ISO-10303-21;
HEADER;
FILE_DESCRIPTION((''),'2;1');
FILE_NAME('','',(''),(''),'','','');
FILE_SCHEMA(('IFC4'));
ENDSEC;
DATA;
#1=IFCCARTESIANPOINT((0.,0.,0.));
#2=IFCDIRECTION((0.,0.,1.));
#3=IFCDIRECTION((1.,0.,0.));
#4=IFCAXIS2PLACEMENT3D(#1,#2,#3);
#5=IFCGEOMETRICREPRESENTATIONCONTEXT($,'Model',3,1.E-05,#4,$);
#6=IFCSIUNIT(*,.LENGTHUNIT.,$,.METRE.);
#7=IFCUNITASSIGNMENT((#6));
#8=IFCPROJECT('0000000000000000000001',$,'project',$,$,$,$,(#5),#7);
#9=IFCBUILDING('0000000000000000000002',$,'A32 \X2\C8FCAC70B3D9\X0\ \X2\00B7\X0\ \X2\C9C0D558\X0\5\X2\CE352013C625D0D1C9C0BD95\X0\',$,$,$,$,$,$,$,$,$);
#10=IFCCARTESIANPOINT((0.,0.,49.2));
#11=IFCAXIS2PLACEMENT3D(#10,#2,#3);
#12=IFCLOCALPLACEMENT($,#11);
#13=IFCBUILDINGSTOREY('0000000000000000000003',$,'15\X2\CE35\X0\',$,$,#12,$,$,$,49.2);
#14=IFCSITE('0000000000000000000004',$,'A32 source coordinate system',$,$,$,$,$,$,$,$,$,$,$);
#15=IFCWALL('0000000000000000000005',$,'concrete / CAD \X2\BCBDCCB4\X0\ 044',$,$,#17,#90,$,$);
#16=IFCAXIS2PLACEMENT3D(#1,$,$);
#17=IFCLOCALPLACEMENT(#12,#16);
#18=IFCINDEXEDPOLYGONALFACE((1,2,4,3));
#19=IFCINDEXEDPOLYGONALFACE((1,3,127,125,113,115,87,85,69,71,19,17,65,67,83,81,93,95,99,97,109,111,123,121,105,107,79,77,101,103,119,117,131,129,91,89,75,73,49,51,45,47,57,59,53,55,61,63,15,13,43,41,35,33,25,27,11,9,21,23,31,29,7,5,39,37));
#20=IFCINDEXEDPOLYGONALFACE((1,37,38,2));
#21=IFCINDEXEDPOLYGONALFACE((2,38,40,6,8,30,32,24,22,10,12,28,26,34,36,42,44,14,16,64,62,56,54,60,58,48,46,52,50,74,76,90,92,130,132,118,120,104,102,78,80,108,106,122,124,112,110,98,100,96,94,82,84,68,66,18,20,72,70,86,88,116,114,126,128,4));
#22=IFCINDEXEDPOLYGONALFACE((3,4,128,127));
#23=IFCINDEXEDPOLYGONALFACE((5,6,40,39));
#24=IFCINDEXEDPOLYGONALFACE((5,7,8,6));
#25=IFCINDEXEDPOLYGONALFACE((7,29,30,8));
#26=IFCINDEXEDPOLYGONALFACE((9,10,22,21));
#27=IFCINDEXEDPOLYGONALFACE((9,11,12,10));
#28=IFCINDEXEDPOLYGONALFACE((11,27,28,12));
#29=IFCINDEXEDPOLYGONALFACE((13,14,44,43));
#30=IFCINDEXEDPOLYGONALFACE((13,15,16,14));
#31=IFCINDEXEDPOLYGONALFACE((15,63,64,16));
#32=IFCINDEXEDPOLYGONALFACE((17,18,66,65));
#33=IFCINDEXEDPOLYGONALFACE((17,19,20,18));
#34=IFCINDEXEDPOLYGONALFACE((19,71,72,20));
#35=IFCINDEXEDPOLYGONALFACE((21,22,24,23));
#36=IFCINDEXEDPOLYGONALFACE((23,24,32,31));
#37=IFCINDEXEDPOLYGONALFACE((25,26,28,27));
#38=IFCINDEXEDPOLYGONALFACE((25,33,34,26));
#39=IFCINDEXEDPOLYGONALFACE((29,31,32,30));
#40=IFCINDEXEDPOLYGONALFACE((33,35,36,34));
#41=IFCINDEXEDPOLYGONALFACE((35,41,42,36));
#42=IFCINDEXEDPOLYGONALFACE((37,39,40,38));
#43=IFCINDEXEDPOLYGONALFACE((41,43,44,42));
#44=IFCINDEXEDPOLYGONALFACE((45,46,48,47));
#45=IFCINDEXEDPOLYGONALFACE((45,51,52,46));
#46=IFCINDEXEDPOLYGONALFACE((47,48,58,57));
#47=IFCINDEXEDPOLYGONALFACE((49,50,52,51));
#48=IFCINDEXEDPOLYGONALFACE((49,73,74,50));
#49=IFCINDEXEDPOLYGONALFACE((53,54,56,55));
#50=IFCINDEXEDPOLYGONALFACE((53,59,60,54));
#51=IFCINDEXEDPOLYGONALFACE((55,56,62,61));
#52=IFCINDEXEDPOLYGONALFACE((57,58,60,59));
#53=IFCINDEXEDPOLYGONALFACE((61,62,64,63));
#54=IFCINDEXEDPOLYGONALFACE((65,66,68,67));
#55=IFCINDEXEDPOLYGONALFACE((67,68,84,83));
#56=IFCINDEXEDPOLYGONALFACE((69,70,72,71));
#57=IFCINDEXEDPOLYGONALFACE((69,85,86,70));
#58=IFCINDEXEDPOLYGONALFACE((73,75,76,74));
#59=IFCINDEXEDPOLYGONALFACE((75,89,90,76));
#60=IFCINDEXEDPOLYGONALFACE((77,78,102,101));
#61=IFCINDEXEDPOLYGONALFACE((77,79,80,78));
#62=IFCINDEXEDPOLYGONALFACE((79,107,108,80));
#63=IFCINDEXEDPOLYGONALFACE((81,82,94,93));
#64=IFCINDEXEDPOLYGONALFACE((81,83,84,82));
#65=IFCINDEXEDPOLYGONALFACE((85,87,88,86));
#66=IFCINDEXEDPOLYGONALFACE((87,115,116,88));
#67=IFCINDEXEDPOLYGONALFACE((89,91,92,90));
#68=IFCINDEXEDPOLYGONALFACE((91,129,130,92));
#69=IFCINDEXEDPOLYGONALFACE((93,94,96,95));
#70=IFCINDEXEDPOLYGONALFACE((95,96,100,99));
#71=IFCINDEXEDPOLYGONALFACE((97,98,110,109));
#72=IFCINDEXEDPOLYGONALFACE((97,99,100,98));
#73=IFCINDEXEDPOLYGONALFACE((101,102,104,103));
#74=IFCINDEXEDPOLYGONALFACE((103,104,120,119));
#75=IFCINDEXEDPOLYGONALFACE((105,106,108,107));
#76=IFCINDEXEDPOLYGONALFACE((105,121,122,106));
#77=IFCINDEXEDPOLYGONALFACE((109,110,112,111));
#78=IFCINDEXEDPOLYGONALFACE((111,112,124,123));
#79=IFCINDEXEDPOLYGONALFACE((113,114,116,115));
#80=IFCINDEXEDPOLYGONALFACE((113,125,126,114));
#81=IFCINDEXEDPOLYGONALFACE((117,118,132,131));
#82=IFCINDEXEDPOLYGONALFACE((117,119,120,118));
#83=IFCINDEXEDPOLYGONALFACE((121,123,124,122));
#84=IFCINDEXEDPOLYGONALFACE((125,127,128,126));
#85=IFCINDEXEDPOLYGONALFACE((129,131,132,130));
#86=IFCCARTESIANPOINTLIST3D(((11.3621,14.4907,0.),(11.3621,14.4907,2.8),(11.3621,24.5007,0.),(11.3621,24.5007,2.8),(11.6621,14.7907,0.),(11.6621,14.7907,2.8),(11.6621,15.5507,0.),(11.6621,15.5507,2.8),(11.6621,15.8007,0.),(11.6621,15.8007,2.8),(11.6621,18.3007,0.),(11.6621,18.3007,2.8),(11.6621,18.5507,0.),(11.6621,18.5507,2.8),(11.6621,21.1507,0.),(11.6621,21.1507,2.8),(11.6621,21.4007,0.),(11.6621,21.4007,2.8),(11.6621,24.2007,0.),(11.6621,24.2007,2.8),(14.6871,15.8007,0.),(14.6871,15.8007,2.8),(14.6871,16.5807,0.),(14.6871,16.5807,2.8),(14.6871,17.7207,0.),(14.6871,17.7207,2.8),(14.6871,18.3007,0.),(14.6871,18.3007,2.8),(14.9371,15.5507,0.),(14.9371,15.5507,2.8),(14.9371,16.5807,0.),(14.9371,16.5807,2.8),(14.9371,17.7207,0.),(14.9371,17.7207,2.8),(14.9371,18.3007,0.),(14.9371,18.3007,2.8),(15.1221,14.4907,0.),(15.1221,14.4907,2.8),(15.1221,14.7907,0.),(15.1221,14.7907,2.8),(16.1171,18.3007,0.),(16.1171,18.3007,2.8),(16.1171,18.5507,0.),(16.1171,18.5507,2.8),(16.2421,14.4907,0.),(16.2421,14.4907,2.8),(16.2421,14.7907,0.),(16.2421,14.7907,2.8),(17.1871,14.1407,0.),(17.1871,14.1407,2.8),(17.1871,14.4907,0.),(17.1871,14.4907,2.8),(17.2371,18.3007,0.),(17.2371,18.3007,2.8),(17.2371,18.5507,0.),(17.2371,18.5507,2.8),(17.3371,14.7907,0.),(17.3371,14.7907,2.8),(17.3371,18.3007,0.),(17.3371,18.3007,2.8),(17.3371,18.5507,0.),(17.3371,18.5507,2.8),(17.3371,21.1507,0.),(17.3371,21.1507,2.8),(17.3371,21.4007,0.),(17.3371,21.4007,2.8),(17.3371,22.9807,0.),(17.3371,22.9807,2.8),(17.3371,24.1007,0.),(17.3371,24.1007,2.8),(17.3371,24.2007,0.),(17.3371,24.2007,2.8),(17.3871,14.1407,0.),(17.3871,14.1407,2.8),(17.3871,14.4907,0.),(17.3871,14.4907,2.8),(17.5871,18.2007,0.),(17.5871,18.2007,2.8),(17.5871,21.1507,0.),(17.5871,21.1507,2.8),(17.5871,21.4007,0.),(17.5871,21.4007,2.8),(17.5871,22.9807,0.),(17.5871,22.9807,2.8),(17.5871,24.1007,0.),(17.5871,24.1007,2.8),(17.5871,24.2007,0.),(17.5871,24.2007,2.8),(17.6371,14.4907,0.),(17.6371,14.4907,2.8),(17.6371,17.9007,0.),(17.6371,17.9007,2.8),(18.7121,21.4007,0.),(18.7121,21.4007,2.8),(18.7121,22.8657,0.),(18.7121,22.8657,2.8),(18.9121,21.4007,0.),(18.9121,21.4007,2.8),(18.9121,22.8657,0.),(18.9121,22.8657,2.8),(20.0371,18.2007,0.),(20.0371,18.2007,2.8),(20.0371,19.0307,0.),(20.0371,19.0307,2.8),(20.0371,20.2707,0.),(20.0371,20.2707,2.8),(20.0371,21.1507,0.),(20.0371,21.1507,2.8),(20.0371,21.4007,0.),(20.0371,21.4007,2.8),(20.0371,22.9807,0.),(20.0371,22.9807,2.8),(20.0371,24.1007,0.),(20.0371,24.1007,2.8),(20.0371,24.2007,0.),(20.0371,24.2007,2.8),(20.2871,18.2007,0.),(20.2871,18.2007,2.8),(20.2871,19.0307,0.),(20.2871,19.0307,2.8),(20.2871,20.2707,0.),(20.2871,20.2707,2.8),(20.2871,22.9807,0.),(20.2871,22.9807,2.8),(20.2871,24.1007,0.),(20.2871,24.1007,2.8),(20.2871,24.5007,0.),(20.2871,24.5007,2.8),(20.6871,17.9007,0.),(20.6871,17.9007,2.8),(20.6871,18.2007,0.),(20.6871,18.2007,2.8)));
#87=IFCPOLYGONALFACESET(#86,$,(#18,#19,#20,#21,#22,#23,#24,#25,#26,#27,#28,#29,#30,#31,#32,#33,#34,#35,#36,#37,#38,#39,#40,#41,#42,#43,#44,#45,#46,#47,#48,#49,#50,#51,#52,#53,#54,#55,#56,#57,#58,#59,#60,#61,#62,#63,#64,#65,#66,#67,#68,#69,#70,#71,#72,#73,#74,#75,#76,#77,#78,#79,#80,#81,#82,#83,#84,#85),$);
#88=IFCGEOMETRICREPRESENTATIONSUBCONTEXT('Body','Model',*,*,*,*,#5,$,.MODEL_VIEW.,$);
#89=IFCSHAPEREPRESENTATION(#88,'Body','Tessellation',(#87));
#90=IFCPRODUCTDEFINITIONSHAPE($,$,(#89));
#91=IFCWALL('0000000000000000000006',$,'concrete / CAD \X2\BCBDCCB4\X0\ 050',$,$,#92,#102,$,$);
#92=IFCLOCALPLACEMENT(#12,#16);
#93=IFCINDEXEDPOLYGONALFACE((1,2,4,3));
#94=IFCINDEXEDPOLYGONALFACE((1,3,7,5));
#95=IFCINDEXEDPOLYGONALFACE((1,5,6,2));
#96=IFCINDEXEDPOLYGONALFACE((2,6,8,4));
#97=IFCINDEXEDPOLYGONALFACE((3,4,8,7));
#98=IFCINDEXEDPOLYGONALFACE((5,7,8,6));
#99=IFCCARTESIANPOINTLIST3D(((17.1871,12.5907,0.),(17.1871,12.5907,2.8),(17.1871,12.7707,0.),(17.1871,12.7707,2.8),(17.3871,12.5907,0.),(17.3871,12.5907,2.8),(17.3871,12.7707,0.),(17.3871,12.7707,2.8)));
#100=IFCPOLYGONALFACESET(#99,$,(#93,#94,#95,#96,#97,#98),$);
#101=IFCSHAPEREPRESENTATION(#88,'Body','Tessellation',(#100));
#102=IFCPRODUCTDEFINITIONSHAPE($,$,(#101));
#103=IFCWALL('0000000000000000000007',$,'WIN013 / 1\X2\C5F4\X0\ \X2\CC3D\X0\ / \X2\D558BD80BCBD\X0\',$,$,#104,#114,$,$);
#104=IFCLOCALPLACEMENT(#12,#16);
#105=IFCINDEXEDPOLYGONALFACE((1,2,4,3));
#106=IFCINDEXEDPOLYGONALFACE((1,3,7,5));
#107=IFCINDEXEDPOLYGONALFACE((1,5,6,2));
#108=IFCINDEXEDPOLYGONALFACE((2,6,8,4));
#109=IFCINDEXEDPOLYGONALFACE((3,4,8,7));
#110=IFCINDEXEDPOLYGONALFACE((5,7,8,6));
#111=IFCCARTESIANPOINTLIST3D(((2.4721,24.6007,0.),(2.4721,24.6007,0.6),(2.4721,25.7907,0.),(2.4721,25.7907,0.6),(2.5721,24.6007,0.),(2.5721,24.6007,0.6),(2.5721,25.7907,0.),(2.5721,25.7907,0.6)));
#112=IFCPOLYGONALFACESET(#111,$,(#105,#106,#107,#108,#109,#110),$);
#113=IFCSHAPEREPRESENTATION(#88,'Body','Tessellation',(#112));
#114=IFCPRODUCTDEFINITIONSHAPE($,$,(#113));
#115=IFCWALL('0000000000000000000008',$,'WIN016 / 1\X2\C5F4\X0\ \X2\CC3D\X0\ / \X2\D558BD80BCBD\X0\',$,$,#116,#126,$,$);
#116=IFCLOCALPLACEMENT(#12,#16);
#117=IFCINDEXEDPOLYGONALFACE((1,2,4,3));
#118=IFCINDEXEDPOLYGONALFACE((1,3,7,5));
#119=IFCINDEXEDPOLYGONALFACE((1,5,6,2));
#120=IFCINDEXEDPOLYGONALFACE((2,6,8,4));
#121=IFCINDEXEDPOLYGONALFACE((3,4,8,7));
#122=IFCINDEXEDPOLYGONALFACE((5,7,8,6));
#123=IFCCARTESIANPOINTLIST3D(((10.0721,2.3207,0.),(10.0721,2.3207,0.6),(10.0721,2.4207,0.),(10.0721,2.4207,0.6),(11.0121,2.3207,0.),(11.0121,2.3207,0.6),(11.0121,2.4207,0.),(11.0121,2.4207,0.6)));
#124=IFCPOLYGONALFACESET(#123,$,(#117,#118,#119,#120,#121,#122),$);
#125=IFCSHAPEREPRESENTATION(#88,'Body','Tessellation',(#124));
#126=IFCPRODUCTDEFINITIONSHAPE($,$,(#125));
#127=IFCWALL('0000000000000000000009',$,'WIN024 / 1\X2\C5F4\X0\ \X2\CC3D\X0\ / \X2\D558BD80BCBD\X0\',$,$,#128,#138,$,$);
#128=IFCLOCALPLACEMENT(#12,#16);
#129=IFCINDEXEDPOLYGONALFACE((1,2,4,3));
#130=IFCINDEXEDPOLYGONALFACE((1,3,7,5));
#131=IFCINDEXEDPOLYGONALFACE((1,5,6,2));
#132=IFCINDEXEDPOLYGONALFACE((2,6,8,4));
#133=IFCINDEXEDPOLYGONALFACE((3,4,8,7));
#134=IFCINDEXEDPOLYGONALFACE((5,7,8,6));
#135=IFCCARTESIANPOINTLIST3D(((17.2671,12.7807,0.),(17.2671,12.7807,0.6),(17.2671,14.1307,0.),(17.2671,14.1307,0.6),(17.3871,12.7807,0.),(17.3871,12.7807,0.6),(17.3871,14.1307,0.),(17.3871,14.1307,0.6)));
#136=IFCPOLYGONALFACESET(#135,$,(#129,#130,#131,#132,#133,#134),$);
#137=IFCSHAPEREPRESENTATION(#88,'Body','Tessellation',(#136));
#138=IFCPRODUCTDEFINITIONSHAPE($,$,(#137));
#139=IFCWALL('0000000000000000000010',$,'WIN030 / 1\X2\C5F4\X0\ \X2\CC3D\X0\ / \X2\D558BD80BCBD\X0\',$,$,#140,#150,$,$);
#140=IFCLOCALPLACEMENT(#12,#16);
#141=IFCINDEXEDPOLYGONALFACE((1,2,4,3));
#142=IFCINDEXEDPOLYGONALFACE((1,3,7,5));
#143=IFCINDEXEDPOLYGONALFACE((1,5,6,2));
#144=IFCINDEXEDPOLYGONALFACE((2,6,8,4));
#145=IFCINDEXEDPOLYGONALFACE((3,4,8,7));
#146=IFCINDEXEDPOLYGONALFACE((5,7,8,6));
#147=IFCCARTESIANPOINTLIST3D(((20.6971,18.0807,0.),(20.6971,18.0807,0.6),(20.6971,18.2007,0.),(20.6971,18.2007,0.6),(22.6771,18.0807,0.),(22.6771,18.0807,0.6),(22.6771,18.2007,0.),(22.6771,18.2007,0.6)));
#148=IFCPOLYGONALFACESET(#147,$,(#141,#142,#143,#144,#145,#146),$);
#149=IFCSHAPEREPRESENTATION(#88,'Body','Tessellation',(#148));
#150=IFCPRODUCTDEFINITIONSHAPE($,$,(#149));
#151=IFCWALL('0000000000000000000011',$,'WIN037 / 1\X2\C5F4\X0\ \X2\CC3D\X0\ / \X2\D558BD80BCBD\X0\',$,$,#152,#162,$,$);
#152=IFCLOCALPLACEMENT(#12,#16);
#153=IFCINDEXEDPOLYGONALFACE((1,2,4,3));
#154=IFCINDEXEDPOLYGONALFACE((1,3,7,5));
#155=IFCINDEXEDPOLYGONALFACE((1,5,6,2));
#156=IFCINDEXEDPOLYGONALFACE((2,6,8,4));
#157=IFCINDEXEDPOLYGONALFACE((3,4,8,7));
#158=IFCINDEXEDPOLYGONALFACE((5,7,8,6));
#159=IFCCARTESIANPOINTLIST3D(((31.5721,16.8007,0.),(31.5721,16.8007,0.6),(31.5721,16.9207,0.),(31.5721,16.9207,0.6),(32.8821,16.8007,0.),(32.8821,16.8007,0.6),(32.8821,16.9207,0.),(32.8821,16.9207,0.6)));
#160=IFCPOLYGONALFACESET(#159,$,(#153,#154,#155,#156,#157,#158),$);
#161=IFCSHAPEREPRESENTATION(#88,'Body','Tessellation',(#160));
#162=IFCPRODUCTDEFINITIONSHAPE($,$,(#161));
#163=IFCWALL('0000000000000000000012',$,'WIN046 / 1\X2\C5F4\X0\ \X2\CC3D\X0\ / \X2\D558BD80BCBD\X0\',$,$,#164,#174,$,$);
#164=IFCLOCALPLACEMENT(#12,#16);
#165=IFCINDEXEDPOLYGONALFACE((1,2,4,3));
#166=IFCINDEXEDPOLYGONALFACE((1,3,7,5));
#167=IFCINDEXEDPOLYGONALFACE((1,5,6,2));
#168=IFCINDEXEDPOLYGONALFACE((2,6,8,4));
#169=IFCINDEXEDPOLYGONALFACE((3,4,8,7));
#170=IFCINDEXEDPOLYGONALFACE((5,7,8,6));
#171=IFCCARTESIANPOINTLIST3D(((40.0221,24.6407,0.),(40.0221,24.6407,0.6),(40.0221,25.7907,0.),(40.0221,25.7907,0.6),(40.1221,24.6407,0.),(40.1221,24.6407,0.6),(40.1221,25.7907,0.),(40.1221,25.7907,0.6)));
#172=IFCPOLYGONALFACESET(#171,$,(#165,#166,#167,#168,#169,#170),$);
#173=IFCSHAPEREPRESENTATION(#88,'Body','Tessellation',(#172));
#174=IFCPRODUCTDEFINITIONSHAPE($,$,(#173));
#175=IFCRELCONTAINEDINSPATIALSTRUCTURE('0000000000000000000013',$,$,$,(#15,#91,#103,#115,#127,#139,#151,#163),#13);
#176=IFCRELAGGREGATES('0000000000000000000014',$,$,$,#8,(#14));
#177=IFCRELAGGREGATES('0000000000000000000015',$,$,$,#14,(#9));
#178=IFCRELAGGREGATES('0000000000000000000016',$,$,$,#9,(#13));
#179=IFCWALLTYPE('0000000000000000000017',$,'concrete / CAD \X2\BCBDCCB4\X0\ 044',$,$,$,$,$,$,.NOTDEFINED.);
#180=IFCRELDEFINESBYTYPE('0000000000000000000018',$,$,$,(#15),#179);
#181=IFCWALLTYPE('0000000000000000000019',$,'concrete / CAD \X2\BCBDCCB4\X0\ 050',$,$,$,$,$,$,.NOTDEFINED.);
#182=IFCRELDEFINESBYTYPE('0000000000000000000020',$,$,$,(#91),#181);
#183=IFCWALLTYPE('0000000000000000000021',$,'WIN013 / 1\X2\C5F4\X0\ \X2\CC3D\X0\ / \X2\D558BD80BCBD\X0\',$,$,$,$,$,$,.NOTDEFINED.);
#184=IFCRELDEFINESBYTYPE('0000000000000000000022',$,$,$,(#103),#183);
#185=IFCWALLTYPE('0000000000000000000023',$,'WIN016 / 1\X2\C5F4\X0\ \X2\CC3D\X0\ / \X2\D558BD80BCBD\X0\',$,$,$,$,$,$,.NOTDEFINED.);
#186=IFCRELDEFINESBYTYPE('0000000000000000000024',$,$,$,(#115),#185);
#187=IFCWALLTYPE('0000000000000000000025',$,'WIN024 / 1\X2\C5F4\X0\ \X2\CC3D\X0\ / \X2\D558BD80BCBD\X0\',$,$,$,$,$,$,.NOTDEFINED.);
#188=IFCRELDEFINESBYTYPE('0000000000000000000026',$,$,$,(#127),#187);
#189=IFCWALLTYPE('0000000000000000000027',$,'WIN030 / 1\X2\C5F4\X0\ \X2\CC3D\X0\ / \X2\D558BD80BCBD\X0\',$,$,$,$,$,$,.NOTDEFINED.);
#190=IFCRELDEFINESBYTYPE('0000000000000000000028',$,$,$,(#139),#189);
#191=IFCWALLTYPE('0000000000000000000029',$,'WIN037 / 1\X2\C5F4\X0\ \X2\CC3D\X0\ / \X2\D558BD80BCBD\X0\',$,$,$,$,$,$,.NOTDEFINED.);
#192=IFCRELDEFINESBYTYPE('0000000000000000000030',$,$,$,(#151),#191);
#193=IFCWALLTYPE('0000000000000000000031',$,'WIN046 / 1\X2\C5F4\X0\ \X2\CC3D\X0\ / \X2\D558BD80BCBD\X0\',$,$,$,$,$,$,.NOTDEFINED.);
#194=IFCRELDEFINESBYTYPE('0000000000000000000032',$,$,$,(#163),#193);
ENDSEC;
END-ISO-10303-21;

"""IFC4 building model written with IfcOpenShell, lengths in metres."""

from ifc_helpers import new_model, si_unit, frame, origin, origin_with_axes, place, context, subcontext, project, spatial, polyline, outline, extrude, source, transform, mapped, type_object, type_shapes, element, save


model = new_model("IFC4")

# Units and contexts
model_context = context("Model", 3, precision=1e-05, world=origin_with_axes())
body_context = subcontext(model_context, "Body", "Model", "MODEL_VIEW")
ifc_project = project(units=[si_unit("LENGTHUNIT", "METRE")], contexts=[model_context])

# Site, building, storey
site = spatial("IfcSite", under=ifc_project, Name="A32 source coordinate system")
building = spatial("IfcBuilding", under=site, Name="A32 주거동 · 지하5층–옥탑지붕")
storey_placement = place(None, frame((0.0, 0.0, 49.2), z_axis=(0.0, 0.0, 1.0), x_axis=(1.0, 0.0, 0.0)))
storey = spatial("IfcBuildingStorey", under=building, at=storey_placement, Name="15층", Elevation=49.2)

# Walls
wall_type_1 = type_object("IfcWallType", Name="concrete / CAD 벽체 044", PredefinedType="NOTDEFINED")
shared_shape_1 = source(origin(), body_context, "Body", "SweptSolid", [
    extrude(outline(polyline([(17.3371, 21.4007), (17.3371, 22.9807), (17.5871, 22.9807), (17.5871, 21.4007), (18.7121, 21.4007), (18.7121, 22.8657), (18.9121, 22.8657), (18.9121, 21.4007), (20.0371, 21.4007), (20.0371, 22.9807), (20.2871, 22.9807), (20.2871, 20.2707), (20.0371, 20.2707), (20.0371, 21.1507), (17.5871, 21.1507), (17.5871, 18.2007), (20.0371, 18.2007), (20.0371, 19.0307), (20.2871, 19.0307), (20.2871, 18.2007), (20.6871, 18.2007), (20.6871, 17.9007), (17.6371, 17.9007), (17.6371, 14.4907), (17.3871, 14.4907), (17.3871, 14.1407), (17.1871, 14.1407), (17.1871, 14.4907), (16.2421, 14.4907), (16.2421, 14.7907), (17.3371, 14.7907), (17.3371, 18.3007), (17.2371, 18.3007), (17.2371, 18.5507), (17.3371, 18.5507), (17.3371, 21.1507), (11.6621, 21.1507), (11.6621, 18.5507), (16.1171, 18.5507), (16.1171, 18.3007), (14.9371, 18.3007), (14.9371, 17.7207), (14.6871, 17.7207), (14.6871, 18.3007), (11.6621, 18.3007), (11.6621, 15.8007), (14.6871, 15.8007), (14.6871, 16.5807), (14.9371, 16.5807), (14.9371, 15.5507), (11.6621, 15.5507), (11.6621, 14.7907), (15.1221, 14.7907), (15.1221, 14.4907), (11.3621, 14.4907), (11.3621, 24.5007), (20.2871, 24.5007), (20.2871, 24.1007), (20.0371, 24.1007), (20.0371, 24.2007), (17.5871, 24.2007), (17.5871, 24.1007), (17.3371, 24.1007), (17.3371, 24.2007), (11.6621, 24.2007), (11.6621, 21.4007), (17.3371, 21.4007)])), origin(), (0.0, 0.0, 1.0), 2.8),
])
type_shapes(wall_type_1, [shared_shape_1])
wall_1_placement = place(storey_placement, origin_with_axes())
element("IfcWall", 1, at=wall_1_placement, inside=storey, type_object=wall_type_1, Name="concrete / CAD 벽체 044", context=body_context, shape_type="MappedRepresentation", body=[
    mapped(shared_shape_1, transform((0.0, 0.0, 0.0), scale=1.0)),
])
wall_type_2 = type_object("IfcWallType", Name="concrete / CAD 벽체 050", PredefinedType="NOTDEFINED")
shared_shape_2 = source(origin(), body_context, "Body", "SweptSolid", [
    extrude(outline(polyline([(17.3871, 12.5907), (17.1871, 12.5907), (17.1871, 12.7707), (17.3871, 12.7707), (17.3871, 12.5907)])), origin(), (0.0, 0.0, 1.0), 2.8),
])
type_shapes(wall_type_2, [shared_shape_2])
wall_2_placement = place(storey_placement, origin_with_axes())
element("IfcWall", 2, at=wall_2_placement, inside=storey, type_object=wall_type_2, Name="concrete / CAD 벽체 050", context=body_context, shape_type="MappedRepresentation", body=[
    mapped(shared_shape_2, transform((0.0, 0.0, 0.0), scale=1.0)),
])
wall_type_3 = type_object("IfcWallType", Name="WIN013 / 1열 창 / 하부벽", PredefinedType="NOTDEFINED")
shared_shape_3 = source(origin(), body_context, "Body", "SweptSolid", [
    extrude(outline(polyline([(2.5721, 25.7907), (2.5721, 24.6007), (2.4721, 24.6007), (2.4721, 25.7907), (2.5721, 25.7907)])), origin(), (0.0, 0.0, 1.0), 0.6),
])
type_shapes(wall_type_3, [shared_shape_3])
wall_3_placement = place(storey_placement, origin_with_axes())
element("IfcWall", 3, at=wall_3_placement, inside=storey, type_object=wall_type_3, Name="WIN013 / 1열 창 / 하부벽", context=body_context, shape_type="MappedRepresentation", body=[
    mapped(shared_shape_3, transform((0.0, 0.0, 0.0), scale=1.0)),
])
wall_type_4 = type_object("IfcWallType", Name="WIN016 / 1열 창 / 하부벽", PredefinedType="NOTDEFINED")
shared_shape_4 = source(origin(), body_context, "Body", "SweptSolid", [
    extrude(outline(polyline([(11.0121, 2.4207), (11.0121, 2.3207), (10.0721, 2.3207), (10.0721, 2.4207), (11.0121, 2.4207)])), origin(), (0.0, 0.0, 1.0), 0.6),
])
type_shapes(wall_type_4, [shared_shape_4])
wall_4_placement = place(storey_placement, origin_with_axes())
element("IfcWall", 4, at=wall_4_placement, inside=storey, type_object=wall_type_4, Name="WIN016 / 1열 창 / 하부벽", context=body_context, shape_type="MappedRepresentation", body=[
    mapped(shared_shape_4, transform((0.0, 0.0, 0.0), scale=1.0)),
])
wall_type_5 = type_object("IfcWallType", Name="WIN024 / 1열 창 / 하부벽", PredefinedType="NOTDEFINED")
shared_shape_5 = source(origin(), body_context, "Body", "SweptSolid", [
    extrude(outline(polyline([(17.3871, 14.1307), (17.3871, 12.7807), (17.2671, 12.7807), (17.2671, 14.1307), (17.3871, 14.1307)])), origin(), (0.0, 0.0, 1.0), 0.6),
])
type_shapes(wall_type_5, [shared_shape_5])
wall_5_placement = place(storey_placement, origin_with_axes())
element("IfcWall", 5, at=wall_5_placement, inside=storey, type_object=wall_type_5, Name="WIN024 / 1열 창 / 하부벽", context=body_context, shape_type="MappedRepresentation", body=[
    mapped(shared_shape_5, transform((0.0, 0.0, 0.0), scale=1.0)),
])
wall_type_6 = type_object("IfcWallType", Name="WIN030 / 1열 창 / 하부벽", PredefinedType="NOTDEFINED")
shared_shape_6 = source(origin(), body_context, "Body", "SweptSolid", [
    extrude(outline(polyline([(22.6771, 18.2007), (22.6771, 18.0807), (20.6971, 18.0807), (20.6971, 18.2007), (22.6771, 18.2007)])), origin(), (0.0, 0.0, 1.0), 0.6),
])
type_shapes(wall_type_6, [shared_shape_6])
wall_6_placement = place(storey_placement, origin_with_axes())
element("IfcWall", 6, at=wall_6_placement, inside=storey, type_object=wall_type_6, Name="WIN030 / 1열 창 / 하부벽", context=body_context, shape_type="MappedRepresentation", body=[
    mapped(shared_shape_6, transform((0.0, 0.0, 0.0), scale=1.0)),
])
wall_type_7 = type_object("IfcWallType", Name="WIN037 / 1열 창 / 하부벽", PredefinedType="NOTDEFINED")
shared_shape_7 = source(origin(), body_context, "Body", "SweptSolid", [
    extrude(outline(polyline([(32.8821, 16.9207), (32.8821, 16.8007), (31.5721, 16.8007), (31.5721, 16.9207), (32.8821, 16.9207)])), origin(), (0.0, 0.0, 1.0), 0.6),
])
type_shapes(wall_type_7, [shared_shape_7])
wall_7_placement = place(storey_placement, origin_with_axes())
element("IfcWall", 7, at=wall_7_placement, inside=storey, type_object=wall_type_7, Name="WIN037 / 1열 창 / 하부벽", context=body_context, shape_type="MappedRepresentation", body=[
    mapped(shared_shape_7, transform((0.0, 0.0, 0.0), scale=1.0)),
])
wall_type_8 = type_object("IfcWallType", Name="WIN046 / 1열 창 / 하부벽", PredefinedType="NOTDEFINED")
shared_shape_8 = source(origin(), body_context, "Body", "SweptSolid", [
    extrude(outline(polyline([(40.1221, 25.7907), (40.1221, 24.6407), (40.0221, 24.6407), (40.0221, 25.7907), (40.1221, 25.7907)])), origin(), (0.0, 0.0, 1.0), 0.6),
])
type_shapes(wall_type_8, [shared_shape_8])
wall_8_placement = place(storey_placement, origin_with_axes())
element("IfcWall", 8, at=wall_8_placement, inside=storey, type_object=wall_type_8, Name="WIN046 / 1열 창 / 하부벽", context=body_context, shape_type="MappedRepresentation", body=[
    mapped(shared_shape_8, transform((0.0, 0.0, 0.0), scale=1.0)),
])

save(model, "model.ifc")
